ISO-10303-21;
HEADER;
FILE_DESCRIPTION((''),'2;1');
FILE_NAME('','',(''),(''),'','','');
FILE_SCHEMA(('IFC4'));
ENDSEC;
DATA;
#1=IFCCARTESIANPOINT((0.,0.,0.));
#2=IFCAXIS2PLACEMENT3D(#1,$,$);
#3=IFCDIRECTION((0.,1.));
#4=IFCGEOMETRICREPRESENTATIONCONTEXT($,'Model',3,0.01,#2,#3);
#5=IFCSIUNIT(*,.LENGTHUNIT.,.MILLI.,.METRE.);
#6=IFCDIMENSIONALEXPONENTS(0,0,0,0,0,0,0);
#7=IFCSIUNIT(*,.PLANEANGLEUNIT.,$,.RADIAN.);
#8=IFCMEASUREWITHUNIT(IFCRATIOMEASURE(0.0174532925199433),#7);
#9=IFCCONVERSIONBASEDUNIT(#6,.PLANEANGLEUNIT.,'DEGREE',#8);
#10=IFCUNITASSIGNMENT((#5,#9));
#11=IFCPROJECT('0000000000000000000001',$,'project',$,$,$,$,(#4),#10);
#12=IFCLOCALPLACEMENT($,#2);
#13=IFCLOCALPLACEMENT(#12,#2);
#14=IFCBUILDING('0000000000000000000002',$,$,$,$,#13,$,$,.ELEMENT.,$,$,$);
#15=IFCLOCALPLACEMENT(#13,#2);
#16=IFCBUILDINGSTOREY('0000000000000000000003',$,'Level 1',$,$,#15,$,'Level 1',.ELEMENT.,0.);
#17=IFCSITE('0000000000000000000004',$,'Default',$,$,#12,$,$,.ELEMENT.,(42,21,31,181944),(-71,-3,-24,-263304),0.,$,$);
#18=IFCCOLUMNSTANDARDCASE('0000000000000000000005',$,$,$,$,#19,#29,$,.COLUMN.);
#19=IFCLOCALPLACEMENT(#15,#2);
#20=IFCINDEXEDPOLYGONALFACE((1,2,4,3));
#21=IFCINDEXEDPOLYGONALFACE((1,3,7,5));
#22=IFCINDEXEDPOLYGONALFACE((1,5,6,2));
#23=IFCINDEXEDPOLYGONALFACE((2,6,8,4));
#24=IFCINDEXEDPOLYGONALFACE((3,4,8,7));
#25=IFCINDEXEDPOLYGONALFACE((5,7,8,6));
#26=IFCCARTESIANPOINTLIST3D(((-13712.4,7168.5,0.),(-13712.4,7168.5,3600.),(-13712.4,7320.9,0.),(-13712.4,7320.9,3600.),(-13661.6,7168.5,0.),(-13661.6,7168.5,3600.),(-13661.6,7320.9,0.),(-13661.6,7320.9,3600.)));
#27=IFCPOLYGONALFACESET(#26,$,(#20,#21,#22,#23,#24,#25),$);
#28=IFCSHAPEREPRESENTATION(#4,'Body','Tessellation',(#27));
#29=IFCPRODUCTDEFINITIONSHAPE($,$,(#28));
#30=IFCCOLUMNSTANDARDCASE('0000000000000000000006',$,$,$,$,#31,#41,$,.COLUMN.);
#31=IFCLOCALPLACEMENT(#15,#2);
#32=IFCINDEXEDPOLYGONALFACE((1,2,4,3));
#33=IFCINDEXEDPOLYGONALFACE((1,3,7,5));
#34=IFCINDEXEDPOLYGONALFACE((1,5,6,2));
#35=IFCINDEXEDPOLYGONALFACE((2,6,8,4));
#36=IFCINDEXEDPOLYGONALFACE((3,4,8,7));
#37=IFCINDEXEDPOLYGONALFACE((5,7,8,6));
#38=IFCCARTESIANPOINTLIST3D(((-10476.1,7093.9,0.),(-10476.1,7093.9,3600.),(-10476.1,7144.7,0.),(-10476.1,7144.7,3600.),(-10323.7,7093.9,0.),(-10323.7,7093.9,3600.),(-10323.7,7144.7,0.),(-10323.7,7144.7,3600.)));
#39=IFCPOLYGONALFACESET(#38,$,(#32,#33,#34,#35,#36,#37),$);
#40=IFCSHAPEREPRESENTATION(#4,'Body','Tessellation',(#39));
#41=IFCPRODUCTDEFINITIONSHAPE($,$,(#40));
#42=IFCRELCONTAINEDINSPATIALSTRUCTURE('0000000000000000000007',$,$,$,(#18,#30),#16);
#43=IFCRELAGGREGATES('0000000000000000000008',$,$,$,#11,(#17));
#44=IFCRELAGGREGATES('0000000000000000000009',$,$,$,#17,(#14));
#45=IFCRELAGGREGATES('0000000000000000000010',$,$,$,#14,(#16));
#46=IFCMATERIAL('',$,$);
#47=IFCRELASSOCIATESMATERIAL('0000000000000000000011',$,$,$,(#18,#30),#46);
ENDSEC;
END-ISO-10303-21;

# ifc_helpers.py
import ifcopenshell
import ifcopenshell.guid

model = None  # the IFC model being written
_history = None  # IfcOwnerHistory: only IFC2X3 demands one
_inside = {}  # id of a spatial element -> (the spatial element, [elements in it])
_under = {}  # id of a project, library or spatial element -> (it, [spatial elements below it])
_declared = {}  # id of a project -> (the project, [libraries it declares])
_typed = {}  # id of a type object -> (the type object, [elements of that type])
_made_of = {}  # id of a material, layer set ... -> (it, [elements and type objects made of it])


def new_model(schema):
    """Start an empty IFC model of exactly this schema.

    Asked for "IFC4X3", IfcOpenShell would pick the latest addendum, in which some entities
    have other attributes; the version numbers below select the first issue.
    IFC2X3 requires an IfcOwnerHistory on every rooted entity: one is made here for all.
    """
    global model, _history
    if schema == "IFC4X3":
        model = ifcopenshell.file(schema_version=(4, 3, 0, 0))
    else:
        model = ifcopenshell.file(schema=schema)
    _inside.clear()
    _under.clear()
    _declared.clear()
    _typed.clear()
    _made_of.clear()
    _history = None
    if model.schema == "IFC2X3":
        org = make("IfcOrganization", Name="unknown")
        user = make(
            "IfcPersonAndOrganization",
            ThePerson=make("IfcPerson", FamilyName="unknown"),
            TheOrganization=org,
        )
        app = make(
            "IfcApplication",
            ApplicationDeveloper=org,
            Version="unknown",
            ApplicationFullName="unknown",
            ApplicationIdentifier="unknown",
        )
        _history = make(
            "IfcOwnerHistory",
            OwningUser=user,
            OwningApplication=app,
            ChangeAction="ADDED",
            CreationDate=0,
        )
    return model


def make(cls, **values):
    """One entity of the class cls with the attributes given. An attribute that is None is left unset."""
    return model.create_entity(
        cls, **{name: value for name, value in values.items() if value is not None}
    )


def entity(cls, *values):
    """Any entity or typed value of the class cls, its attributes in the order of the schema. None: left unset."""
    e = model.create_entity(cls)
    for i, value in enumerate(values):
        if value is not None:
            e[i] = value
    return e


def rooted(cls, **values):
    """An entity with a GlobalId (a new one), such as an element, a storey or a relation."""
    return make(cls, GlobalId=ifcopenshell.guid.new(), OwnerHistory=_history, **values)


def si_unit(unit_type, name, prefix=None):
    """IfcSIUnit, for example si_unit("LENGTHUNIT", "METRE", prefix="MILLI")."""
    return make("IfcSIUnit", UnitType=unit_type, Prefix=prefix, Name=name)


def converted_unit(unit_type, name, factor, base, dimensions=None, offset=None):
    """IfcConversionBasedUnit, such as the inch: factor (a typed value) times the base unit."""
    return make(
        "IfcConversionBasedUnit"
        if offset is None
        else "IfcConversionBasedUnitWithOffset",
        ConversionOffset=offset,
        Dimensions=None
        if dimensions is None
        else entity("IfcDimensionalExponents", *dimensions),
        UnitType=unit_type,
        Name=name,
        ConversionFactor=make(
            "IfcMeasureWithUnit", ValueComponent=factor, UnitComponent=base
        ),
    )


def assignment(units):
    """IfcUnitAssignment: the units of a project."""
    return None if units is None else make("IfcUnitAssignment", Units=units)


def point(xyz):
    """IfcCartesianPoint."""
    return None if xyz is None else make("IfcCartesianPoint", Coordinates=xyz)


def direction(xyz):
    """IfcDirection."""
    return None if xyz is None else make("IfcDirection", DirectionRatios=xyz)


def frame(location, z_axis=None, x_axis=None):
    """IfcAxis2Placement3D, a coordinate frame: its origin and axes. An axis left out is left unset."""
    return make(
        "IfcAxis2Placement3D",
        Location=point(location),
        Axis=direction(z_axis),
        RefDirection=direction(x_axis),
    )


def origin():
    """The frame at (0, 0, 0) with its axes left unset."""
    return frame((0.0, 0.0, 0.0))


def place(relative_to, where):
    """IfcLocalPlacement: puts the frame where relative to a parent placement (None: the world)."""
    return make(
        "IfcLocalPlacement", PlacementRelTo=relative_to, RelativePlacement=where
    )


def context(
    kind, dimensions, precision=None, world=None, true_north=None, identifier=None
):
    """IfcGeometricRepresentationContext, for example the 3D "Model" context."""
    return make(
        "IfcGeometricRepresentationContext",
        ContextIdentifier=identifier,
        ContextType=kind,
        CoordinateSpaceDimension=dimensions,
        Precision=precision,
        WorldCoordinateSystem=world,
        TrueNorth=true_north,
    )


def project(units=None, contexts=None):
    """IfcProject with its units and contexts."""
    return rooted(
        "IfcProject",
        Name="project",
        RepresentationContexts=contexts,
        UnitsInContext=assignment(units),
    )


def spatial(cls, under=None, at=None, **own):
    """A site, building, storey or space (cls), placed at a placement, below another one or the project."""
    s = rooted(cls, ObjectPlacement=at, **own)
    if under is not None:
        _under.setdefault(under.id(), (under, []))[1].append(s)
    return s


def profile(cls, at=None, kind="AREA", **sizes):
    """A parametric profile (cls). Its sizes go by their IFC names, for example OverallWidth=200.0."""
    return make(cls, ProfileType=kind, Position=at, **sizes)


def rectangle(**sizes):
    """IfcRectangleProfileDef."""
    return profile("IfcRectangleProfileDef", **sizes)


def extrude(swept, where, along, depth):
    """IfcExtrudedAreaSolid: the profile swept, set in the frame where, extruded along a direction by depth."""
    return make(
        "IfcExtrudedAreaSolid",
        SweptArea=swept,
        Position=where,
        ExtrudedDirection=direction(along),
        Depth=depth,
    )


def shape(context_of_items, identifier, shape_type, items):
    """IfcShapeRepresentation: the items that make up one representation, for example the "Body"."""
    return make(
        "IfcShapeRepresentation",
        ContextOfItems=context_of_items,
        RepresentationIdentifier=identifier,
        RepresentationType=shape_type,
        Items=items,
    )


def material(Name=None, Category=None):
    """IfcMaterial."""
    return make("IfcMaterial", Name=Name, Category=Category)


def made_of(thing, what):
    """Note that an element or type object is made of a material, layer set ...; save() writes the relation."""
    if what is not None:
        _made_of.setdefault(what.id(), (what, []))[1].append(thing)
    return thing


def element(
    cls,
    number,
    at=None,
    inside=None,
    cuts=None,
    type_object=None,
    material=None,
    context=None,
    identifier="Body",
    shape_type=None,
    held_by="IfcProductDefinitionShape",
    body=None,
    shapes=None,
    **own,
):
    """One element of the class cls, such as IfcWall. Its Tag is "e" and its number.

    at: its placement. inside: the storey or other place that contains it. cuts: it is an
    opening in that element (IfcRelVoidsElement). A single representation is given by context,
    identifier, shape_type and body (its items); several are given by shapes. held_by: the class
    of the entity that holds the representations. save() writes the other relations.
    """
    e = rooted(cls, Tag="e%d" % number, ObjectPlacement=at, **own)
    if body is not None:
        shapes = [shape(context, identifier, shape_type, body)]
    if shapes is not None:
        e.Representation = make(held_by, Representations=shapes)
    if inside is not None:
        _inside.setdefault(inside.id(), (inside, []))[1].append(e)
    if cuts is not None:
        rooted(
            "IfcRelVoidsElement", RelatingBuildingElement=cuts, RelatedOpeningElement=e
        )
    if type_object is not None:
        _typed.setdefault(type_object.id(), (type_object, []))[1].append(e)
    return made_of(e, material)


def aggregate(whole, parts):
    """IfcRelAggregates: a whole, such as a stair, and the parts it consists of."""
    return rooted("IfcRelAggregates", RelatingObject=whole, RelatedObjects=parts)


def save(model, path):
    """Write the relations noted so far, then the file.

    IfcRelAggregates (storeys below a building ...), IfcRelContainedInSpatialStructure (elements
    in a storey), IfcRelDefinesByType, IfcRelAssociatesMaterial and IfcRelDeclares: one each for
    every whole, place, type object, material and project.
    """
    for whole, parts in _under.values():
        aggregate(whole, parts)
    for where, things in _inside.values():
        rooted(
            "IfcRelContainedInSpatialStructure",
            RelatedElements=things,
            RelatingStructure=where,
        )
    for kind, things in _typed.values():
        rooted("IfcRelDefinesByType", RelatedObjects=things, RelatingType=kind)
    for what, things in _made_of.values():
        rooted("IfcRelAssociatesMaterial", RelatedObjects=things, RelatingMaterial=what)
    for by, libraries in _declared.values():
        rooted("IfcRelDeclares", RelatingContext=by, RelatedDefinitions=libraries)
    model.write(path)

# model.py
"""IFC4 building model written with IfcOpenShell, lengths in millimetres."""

from ifc_helpers import new_model, entity, si_unit, converted_unit, direction, frame, origin, place, context, project, spatial, rectangle, extrude, material, element, save


model = new_model("IFC4")

# Units and contexts
model_context = context("Model", 3, precision=0.01, world=origin(), true_north=direction((0.0, 1.0)))
ifc_project = project(units=[si_unit("LENGTHUNIT", "METRE", prefix="MILLI"), converted_unit("PLANEANGLEUNIT", "DEGREE", entity("IfcRatioMeasure", 0.0174532925199433), si_unit("PLANEANGLEUNIT", "RADIAN"), dimensions=[0, 0, 0, 0, 0, 0, 0])], contexts=[model_context])

# Site, building, storey
site_placement = place(None, origin())
site = spatial("IfcSite", under=ifc_project, at=site_placement, Name="Default", CompositionType="ELEMENT", RefLatitude=(42, 21, 31, 181944), RefLongitude=(-71, -3, -24, -263304), RefElevation=0.0)
building_placement = place(site_placement, origin())
building = spatial("IfcBuilding", under=site, at=building_placement, CompositionType="ELEMENT")
storey_placement = place(building_placement, origin())
storey = spatial("IfcBuildingStorey", under=building, at=storey_placement, Name="Level 1", LongName="Level 1", CompositionType="ELEMENT", Elevation=0.0)

# Columns
ifc_material_1 = material(Name="")
placement_1 = place(storey_placement, frame((-13712.4, 7244.7, 0.0)))
for number, where, z_axis, x_axis in (
    (1, (25.4, 0.0, 0.0), (0.0, 0.0, 1.0), (1.0, 0.0, 0.0)),
):
    element("IfcColumnStandardCase", number, at=place(placement_1, frame(where, z_axis=z_axis, x_axis=x_axis)), inside=storey, material=ifc_material_1, PredefinedType="COLUMN", context=model_context, shape_type="SweptSolid", body=[
        extrude(rectangle(XDim=50.8, YDim=152.4), origin(), (0.0, 0.0, 1.0), 3600.0),
    ])
placement_2 = place(storey_placement, frame((-10399.9, 7144.7, 0.0), z_axis=(0.0, 0.0, 1.0), x_axis=(0.0, -1.0, 0.0)))
for number, where, z_axis, x_axis in (
    (2, (25.4, 0.0, 0.0), (0.0, 0.0, 1.0), (1.0, 0.0, 0.0)),
):
    element("IfcColumnStandardCase", number, at=place(placement_2, frame(where, z_axis=z_axis, x_axis=x_axis)), inside=storey, material=ifc_material_1, PredefinedType="COLUMN", context=model_context, shape_type="SweptSolid", body=[
        extrude(rectangle(XDim=50.8, YDim=152.4), origin(), (0.0, 0.0, 1.0), 3600.0),
    ])

save(model, "model.ifc")
